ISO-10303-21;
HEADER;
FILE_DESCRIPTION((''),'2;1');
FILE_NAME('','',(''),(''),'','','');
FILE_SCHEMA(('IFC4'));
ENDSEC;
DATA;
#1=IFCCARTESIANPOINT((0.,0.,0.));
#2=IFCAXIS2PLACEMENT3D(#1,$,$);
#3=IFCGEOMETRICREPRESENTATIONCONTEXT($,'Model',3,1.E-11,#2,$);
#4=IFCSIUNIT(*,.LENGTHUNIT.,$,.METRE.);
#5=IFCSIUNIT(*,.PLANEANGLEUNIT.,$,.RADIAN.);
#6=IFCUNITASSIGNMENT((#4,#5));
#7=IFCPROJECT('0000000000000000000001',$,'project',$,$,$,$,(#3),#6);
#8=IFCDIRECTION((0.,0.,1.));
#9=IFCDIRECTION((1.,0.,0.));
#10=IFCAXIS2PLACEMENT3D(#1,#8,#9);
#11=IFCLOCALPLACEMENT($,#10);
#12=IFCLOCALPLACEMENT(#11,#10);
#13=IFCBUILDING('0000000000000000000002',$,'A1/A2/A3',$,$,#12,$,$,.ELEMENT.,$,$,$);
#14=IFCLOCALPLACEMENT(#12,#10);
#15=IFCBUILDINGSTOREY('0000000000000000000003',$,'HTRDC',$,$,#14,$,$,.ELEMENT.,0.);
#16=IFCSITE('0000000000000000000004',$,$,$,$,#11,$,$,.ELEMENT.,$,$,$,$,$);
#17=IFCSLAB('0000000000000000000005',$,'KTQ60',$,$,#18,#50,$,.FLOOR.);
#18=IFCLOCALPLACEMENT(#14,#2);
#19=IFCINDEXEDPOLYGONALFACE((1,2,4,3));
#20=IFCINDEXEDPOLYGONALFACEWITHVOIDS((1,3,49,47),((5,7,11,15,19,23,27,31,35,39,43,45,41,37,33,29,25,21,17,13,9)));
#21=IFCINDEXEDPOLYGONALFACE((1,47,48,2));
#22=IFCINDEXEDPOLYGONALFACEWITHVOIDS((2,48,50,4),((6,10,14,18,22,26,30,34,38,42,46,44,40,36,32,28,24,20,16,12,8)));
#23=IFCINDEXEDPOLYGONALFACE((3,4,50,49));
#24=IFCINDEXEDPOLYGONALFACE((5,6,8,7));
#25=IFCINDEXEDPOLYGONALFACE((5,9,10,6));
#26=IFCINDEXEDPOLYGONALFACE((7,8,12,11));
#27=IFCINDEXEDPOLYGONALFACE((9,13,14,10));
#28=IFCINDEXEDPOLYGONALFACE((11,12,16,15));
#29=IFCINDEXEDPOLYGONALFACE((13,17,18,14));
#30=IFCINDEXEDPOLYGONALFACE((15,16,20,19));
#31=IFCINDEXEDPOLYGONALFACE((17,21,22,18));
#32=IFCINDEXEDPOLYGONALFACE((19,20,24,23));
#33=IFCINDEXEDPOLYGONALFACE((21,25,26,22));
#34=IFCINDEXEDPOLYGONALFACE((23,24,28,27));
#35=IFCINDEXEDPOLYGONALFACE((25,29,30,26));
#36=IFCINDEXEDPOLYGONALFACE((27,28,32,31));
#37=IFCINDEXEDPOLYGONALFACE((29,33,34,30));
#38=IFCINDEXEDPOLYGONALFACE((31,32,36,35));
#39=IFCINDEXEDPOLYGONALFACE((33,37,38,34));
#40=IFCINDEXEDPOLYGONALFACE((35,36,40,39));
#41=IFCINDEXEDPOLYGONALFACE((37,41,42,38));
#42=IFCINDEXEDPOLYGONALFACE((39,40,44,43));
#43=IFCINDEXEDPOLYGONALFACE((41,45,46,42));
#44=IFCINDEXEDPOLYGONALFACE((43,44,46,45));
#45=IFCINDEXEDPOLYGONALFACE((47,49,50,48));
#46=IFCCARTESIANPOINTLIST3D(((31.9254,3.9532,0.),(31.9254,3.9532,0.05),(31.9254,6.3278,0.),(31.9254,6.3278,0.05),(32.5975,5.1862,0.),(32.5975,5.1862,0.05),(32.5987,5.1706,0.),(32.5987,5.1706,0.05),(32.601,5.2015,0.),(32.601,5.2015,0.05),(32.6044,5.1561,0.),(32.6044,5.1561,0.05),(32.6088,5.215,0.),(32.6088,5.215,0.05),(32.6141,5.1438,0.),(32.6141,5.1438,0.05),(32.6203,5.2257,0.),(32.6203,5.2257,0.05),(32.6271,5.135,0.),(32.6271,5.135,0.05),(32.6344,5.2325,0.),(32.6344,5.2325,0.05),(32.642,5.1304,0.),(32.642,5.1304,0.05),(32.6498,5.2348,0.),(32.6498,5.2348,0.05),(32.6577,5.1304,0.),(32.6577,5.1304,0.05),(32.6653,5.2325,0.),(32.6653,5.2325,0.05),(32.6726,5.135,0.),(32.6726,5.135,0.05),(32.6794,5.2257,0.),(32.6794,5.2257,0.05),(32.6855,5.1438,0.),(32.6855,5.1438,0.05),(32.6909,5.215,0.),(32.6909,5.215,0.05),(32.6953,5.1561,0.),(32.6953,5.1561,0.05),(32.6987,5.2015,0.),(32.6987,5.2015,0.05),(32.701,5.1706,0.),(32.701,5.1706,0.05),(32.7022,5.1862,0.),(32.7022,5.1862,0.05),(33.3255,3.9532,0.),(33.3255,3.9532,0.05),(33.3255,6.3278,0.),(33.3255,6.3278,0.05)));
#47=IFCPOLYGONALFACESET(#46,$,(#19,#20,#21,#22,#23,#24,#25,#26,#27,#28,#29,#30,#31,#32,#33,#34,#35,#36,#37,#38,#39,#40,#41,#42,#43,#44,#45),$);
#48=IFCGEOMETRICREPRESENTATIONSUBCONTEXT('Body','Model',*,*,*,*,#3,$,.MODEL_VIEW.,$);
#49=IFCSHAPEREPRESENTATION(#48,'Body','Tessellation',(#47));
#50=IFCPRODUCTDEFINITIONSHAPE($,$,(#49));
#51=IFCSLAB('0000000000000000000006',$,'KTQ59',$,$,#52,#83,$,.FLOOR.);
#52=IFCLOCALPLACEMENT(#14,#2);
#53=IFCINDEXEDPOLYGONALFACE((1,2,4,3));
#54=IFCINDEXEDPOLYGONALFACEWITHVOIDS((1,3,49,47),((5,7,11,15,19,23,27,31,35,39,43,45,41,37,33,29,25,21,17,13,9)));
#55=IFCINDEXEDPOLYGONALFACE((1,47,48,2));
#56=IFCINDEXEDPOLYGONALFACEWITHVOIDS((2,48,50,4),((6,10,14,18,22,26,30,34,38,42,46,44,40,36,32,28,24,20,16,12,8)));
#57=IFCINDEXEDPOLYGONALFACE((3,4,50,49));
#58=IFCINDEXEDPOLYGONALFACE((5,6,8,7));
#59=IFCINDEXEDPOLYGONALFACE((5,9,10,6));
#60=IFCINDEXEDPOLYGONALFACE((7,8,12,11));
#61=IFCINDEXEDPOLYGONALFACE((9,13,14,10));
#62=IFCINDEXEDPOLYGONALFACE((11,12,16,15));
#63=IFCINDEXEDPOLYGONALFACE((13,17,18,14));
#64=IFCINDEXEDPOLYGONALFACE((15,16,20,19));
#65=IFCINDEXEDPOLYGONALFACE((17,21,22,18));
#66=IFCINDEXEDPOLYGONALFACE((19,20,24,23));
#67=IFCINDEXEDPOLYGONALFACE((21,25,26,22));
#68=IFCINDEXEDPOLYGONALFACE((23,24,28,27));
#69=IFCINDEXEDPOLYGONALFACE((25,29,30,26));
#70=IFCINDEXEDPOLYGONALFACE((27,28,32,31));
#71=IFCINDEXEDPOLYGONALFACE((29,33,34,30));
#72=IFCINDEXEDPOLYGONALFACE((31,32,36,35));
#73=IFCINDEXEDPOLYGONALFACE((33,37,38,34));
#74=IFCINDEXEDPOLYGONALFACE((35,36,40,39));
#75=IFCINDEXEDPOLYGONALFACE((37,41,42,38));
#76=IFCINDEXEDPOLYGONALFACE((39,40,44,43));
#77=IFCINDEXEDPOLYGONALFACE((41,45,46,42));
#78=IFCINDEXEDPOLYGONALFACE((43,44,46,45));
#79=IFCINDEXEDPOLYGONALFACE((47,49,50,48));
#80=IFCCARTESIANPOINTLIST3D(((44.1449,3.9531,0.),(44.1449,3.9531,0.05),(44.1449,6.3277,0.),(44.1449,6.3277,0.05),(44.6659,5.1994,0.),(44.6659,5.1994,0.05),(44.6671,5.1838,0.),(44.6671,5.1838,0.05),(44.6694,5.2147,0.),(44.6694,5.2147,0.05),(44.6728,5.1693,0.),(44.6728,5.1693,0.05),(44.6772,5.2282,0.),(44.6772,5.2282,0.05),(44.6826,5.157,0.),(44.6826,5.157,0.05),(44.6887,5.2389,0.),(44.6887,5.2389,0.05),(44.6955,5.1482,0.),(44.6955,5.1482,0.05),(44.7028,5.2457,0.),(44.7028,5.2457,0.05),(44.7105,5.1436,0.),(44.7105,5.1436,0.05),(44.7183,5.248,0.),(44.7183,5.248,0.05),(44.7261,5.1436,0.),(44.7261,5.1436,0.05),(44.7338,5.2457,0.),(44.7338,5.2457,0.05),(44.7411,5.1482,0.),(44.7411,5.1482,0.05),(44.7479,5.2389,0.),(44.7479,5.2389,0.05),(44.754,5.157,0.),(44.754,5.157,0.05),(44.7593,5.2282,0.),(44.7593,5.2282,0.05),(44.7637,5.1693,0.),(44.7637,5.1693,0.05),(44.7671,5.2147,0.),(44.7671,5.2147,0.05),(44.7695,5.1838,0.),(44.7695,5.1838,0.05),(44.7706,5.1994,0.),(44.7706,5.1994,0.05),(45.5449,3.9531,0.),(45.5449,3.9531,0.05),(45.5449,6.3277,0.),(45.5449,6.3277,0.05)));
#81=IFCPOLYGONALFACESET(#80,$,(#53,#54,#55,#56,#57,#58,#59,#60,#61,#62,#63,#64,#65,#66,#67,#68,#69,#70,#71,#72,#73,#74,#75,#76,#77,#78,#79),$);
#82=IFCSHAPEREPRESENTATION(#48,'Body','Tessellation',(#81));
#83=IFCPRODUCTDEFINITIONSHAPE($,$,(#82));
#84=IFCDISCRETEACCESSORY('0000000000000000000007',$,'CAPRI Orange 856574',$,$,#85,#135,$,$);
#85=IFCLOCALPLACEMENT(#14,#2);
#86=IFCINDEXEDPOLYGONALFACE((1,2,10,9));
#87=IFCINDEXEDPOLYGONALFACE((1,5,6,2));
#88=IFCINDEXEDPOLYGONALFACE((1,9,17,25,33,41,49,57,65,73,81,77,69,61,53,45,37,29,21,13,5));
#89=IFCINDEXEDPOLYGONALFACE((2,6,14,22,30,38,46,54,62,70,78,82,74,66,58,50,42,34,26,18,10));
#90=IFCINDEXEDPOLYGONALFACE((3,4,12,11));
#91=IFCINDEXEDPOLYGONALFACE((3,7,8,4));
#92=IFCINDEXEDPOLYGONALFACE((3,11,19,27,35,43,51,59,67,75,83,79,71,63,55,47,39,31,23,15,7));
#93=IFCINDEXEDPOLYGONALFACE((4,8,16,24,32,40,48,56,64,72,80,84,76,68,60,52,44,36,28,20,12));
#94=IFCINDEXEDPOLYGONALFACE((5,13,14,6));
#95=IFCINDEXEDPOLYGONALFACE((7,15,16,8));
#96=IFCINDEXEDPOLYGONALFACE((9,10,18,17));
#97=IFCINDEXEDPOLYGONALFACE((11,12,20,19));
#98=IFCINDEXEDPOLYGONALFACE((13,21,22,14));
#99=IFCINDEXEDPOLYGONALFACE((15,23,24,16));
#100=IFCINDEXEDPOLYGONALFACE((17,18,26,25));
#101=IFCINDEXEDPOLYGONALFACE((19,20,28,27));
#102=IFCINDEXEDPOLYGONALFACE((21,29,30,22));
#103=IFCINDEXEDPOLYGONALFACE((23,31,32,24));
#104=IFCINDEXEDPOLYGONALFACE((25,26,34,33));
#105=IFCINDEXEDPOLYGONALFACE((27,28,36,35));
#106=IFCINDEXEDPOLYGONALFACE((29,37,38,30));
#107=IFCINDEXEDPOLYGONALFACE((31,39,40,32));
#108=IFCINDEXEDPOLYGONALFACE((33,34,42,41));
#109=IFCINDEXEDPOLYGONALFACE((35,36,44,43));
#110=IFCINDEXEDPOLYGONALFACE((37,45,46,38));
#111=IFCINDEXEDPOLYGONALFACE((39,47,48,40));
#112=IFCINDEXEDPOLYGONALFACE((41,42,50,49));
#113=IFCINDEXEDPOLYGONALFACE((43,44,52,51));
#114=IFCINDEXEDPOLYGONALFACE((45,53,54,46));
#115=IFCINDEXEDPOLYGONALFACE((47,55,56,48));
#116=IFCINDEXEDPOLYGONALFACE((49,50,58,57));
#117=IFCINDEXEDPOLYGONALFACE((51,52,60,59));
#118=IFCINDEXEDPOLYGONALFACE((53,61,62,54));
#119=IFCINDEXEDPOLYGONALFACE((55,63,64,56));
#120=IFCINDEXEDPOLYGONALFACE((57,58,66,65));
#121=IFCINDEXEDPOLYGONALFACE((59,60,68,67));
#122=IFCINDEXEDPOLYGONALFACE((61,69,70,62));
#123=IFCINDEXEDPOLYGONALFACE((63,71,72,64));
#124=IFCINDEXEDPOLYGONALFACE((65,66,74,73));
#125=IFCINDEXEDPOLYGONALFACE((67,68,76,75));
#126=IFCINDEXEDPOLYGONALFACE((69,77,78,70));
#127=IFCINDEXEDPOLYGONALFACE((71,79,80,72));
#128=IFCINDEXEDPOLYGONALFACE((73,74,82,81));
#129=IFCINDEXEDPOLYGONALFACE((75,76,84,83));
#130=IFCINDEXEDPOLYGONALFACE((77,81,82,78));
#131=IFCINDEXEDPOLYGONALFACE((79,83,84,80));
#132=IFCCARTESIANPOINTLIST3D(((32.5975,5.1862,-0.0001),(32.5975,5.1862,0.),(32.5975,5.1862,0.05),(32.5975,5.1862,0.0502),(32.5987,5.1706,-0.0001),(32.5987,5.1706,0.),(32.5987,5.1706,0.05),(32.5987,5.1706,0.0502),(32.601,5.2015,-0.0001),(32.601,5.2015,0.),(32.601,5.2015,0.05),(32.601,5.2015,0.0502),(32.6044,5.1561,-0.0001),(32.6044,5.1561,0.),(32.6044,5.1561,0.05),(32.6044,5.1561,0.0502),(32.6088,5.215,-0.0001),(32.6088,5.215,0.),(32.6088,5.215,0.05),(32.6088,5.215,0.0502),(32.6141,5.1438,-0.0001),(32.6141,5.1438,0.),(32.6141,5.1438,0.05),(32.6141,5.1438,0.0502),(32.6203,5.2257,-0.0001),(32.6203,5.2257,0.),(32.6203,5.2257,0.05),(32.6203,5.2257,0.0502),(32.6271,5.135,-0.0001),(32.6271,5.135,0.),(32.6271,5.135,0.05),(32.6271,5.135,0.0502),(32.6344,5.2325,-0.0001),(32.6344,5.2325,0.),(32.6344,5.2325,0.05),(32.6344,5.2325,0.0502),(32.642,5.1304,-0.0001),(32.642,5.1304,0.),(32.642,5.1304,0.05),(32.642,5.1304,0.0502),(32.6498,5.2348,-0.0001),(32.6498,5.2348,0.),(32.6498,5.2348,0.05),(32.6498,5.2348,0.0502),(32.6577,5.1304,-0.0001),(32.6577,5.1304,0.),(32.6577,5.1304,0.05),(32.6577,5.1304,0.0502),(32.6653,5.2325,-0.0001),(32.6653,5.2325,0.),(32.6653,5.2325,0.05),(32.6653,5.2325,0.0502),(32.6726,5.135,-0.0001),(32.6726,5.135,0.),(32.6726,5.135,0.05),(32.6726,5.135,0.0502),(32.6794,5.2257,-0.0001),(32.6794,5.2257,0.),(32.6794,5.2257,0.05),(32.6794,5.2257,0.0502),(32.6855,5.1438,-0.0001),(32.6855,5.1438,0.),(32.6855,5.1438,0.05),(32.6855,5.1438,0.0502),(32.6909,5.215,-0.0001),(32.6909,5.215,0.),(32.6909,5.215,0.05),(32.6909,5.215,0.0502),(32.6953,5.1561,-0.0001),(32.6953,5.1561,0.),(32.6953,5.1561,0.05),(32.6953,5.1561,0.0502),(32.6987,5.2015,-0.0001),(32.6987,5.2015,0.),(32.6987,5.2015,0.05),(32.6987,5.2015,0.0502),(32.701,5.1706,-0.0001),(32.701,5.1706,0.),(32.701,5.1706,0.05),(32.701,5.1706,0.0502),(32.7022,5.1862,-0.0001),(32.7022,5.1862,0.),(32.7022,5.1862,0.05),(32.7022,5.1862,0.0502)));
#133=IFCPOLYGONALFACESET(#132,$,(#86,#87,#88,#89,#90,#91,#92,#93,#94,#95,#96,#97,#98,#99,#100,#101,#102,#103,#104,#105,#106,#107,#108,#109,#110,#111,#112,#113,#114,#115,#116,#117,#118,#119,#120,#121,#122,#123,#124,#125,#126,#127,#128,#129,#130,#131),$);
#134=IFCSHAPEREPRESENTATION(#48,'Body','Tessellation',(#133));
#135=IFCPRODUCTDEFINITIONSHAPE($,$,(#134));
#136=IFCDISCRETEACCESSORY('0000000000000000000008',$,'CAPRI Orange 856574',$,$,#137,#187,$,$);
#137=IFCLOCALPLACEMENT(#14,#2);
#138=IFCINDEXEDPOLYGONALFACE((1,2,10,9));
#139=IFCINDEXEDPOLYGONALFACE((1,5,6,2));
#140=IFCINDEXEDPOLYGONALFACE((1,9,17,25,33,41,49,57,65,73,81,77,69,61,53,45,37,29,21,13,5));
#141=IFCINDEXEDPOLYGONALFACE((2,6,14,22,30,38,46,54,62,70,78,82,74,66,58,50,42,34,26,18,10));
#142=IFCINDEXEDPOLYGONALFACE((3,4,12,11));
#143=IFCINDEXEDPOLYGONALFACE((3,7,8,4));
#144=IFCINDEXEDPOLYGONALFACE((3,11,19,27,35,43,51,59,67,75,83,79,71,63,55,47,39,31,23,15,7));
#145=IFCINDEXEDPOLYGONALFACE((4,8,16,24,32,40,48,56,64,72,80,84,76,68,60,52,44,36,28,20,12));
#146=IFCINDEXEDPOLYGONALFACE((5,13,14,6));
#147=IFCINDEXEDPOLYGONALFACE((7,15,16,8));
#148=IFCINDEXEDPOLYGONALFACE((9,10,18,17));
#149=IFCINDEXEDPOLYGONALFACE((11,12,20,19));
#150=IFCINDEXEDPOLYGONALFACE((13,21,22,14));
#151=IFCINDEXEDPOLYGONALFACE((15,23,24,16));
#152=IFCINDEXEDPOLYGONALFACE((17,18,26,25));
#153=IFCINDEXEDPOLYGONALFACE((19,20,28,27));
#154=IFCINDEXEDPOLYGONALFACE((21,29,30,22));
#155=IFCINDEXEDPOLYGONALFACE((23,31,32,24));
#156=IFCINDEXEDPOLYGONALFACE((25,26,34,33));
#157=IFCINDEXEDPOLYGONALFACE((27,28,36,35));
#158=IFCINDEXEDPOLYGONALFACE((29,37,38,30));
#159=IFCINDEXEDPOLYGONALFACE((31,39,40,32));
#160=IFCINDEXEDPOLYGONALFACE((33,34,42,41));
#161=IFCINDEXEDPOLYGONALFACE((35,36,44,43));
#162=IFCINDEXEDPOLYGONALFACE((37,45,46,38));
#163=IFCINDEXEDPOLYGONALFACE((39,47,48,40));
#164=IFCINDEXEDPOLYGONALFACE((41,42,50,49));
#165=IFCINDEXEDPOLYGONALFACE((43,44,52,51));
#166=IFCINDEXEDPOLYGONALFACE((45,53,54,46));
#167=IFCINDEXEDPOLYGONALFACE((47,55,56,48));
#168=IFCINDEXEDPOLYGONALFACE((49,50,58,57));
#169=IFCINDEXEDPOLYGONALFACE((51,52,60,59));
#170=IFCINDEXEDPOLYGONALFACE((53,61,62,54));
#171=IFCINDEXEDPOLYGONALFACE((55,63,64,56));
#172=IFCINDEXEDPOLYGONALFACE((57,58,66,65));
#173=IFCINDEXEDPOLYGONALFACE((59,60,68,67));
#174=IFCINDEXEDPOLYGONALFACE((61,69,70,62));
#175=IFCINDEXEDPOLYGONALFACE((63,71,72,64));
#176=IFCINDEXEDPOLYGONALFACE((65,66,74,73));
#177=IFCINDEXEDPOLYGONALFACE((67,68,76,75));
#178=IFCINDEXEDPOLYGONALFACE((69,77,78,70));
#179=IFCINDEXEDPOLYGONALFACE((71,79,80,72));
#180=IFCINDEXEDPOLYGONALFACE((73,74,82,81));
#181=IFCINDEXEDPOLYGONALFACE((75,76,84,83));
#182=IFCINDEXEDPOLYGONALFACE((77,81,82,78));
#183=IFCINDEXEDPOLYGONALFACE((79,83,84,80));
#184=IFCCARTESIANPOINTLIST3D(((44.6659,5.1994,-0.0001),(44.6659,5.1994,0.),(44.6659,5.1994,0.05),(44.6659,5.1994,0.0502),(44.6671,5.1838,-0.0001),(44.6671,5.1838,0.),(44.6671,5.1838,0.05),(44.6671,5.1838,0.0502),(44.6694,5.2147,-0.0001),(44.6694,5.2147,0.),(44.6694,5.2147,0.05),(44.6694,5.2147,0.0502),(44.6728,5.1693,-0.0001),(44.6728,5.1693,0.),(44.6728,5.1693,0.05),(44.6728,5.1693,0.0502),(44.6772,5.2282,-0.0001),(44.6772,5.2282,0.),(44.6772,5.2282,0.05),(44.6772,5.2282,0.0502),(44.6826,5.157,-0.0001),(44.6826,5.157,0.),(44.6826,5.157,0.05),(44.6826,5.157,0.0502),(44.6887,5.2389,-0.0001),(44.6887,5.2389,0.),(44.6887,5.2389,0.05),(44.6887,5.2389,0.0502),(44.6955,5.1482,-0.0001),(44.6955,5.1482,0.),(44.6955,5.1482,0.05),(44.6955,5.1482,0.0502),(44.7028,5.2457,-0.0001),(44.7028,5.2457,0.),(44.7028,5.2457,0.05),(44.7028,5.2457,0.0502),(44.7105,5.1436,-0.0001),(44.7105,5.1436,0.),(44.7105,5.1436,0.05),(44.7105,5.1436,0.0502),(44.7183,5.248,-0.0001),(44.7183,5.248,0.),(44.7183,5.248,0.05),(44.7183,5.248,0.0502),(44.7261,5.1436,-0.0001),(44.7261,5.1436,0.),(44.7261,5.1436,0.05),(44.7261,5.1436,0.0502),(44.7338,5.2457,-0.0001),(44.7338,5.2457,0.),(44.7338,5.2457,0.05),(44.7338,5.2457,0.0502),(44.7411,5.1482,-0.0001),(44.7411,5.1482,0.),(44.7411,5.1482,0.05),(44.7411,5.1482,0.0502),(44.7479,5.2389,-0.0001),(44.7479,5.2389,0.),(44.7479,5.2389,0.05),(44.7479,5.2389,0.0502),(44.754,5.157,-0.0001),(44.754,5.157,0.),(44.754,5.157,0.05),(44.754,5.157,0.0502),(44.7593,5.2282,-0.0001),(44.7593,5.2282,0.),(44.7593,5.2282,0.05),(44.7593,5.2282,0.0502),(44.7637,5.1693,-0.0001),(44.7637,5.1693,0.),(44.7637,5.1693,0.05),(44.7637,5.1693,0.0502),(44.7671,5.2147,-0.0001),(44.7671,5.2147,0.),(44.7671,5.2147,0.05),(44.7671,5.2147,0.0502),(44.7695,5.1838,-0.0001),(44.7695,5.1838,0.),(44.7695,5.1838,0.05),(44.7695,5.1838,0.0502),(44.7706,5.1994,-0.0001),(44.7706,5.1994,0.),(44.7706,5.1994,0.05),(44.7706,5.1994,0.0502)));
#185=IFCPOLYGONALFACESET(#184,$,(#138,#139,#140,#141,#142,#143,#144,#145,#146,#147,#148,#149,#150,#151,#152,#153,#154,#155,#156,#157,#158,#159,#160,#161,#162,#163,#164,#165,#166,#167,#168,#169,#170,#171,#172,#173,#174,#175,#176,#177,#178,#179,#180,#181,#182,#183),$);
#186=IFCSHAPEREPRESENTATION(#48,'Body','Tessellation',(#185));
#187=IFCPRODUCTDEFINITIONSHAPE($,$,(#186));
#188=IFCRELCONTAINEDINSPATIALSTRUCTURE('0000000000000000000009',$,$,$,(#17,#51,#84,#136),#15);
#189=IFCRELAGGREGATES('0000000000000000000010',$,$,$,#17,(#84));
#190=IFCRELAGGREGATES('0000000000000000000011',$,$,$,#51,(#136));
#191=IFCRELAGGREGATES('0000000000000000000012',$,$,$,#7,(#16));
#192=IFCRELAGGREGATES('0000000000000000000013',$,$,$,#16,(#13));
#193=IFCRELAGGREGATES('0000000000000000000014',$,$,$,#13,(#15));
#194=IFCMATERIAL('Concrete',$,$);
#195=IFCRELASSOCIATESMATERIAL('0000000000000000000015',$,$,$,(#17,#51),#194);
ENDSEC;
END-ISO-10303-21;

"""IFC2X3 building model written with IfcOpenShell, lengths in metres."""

from ifc_helpers import new_model, si_unit, frame, frame_2d, origin, origin_with_axes, origin_2d_with_axis, place, context, subcontext, project, spatial, polyline, circle, outline, extrude, material, element, aggregate, save


model = new_model("IFC2X3")

# Units and contexts
model_context = context("Model", 3, precision=1e-11, world=origin())
body_context = subcontext(model_context, "Body", "Model", "MODEL_VIEW")
ifc_project = project(units=[si_unit("LENGTHUNIT", "METRE"), si_unit("PLANEANGLEUNIT", "RADIAN")], contexts=[model_context])

# Site, building, storey
site_placement = place(None, origin_with_axes())
site = spatial("IfcSite", under=ifc_project, at=site_placement, CompositionType="ELEMENT")
building_placement = place(site_placement, origin_with_axes())
building = spatial("IfcBuilding", under=site, at=building_placement, Name="A1/A2/A3", CompositionType="ELEMENT")
storey_placement = place(building_placement, origin_with_axes())
storey = spatial("IfcBuildingStorey", under=building, at=storey_placement, Name="HTRDC", CompositionType="ELEMENT", Elevation=0.0)

# Slabs, openings
ifc_material = material(Name="Concrete")
slab_1_placement = place(storey_placement, frame((31.9255, 3.9532, 0.0), z_axis=(0.0, 0.0, 1.0), x_axis=(1.0, 0.0, 0.0)))
slab_1 = element("IfcSlab", 1, at=slab_1_placement, inside=storey, material=ifc_material, Name="KTQ60", PredefinedType="FLOOR", context=body_context, shape_type="SweptSolid", body=[
    extrude(outline(polyline([(0.0, 0.0), (0.0, -1.4), (2.3746, -1.4), (2.3746, 0.0), (0.0, 0.0)])), frame((0.0, 0.0, 0.0), z_axis=(0.0, 0.0, 1.0), x_axis=(0.0, 1.0, 0.0)), (0.0, 0.0, 1.0), 0.05),
])
opening_1_placement = place(slab_1_placement, frame((0.7244, 1.2291, 0.0), z_axis=(0.0, 0.0, 1.0), x_axis=(1.0, 0.0, 0.0)))
element("IfcOpeningElement", 2, at=opening_1_placement, cuts=slab_1, ObjectType="Opening", context=body_context, shape_type="SweptSolid", body=[
    extrude(circle(Radius=0.0525, at=origin_2d_with_axis()), frame((0.0, 0.0, 0.0), z_axis=(0.0, 0.0, 1.0), x_axis=(0.0, 1.0, 0.0)), (0.0, 0.0, 1.0), 0.05),
])
slab_2_placement = place(storey_placement, frame((44.1449, 3.9531, 0.0), z_axis=(0.0, 0.0, 1.0), x_axis=(1.0, 0.0, 0.0)))
slab_2 = element("IfcSlab", 3, at=slab_2_placement, inside=storey, material=ifc_material, Name="KTQ59", PredefinedType="FLOOR", context=body_context, shape_type="SweptSolid", body=[
    extrude(outline(polyline([(0.0, 0.0), (0.0, -1.4), (2.3746, -1.4), (2.3746, 0.0), (0.0, 0.0)])), frame((0.0, 0.0, 0.0), z_axis=(0.0, 0.0, 1.0), x_axis=(0.0, 1.0, 0.0)), (0.0, 0.0, 1.0), 0.05),
])
opening_2_placement = place(slab_2_placement, frame((0.5734, 1.2424, 0.0), z_axis=(0.0, 0.0, 1.0), x_axis=(1.0, 0.0, 0.0)))
element("IfcOpeningElement", 4, at=opening_2_placement, cuts=slab_2, ObjectType="Opening", context=body_context, shape_type="SweptSolid", body=[
    extrude(circle(Radius=0.0525, at=origin_2d_with_axis()), frame((0.0, 0.0, 0.0), z_axis=(0.0, 0.0, 1.0), x_axis=(0.0, 1.0, 0.0)), (0.0, 0.0, 1.0), 0.05),
])

# Discrete accessories
discrete_accessory_1_placement = place(storey_placement, frame((31.9255, 3.9532, -0.0001), z_axis=(0.0, 0.0, 1.0), x_axis=(1.0, 0.0, 0.0)))
discrete_accessory_1 = element("IfcDiscreteAccessory", 5, at=discrete_accessory_1_placement, inside=storey, Name="CAPRI Orange 856574", context=body_context, shape_type="SweptSolid", body=[
    extrude(circle(Radius=0.0525, at=frame_2d((1.2291, -0.7244), x_axis=(1.0, 0.0))), frame((0.0, 0.0, 0.0), z_axis=(0.0, 0.0, 1.0), x_axis=(0.0, 1.0, 0.0)), (0.0, 0.0, 1.0), 0.0503),
])
aggregate(slab_1, [discrete_accessory_1])
discrete_accessory_2_placement = place(storey_placement, frame((44.1449, 3.9531, -0.0001), z_axis=(0.0, 0.0, 1.0), x_axis=(1.0, 0.0, 0.0)))
discrete_accessory_2 = element("IfcDiscreteAccessory", 6, at=discrete_accessory_2_placement, inside=storey, Name="CAPRI Orange 856574", context=body_context, shape_type="SweptSolid", body=[
    extrude(circle(Radius=0.0525, at=frame_2d((1.2424, -0.5734), x_axis=(1.0, 0.0))), frame((0.0, 0.0, 0.0), z_axis=(0.0, 0.0, 1.0), x_axis=(0.0, 1.0, 0.0)), (0.0, 0.0, 1.0), 0.0503),
])
aggregate(slab_2, [discrete_accessory_2])

save(model, "model.ifc")
